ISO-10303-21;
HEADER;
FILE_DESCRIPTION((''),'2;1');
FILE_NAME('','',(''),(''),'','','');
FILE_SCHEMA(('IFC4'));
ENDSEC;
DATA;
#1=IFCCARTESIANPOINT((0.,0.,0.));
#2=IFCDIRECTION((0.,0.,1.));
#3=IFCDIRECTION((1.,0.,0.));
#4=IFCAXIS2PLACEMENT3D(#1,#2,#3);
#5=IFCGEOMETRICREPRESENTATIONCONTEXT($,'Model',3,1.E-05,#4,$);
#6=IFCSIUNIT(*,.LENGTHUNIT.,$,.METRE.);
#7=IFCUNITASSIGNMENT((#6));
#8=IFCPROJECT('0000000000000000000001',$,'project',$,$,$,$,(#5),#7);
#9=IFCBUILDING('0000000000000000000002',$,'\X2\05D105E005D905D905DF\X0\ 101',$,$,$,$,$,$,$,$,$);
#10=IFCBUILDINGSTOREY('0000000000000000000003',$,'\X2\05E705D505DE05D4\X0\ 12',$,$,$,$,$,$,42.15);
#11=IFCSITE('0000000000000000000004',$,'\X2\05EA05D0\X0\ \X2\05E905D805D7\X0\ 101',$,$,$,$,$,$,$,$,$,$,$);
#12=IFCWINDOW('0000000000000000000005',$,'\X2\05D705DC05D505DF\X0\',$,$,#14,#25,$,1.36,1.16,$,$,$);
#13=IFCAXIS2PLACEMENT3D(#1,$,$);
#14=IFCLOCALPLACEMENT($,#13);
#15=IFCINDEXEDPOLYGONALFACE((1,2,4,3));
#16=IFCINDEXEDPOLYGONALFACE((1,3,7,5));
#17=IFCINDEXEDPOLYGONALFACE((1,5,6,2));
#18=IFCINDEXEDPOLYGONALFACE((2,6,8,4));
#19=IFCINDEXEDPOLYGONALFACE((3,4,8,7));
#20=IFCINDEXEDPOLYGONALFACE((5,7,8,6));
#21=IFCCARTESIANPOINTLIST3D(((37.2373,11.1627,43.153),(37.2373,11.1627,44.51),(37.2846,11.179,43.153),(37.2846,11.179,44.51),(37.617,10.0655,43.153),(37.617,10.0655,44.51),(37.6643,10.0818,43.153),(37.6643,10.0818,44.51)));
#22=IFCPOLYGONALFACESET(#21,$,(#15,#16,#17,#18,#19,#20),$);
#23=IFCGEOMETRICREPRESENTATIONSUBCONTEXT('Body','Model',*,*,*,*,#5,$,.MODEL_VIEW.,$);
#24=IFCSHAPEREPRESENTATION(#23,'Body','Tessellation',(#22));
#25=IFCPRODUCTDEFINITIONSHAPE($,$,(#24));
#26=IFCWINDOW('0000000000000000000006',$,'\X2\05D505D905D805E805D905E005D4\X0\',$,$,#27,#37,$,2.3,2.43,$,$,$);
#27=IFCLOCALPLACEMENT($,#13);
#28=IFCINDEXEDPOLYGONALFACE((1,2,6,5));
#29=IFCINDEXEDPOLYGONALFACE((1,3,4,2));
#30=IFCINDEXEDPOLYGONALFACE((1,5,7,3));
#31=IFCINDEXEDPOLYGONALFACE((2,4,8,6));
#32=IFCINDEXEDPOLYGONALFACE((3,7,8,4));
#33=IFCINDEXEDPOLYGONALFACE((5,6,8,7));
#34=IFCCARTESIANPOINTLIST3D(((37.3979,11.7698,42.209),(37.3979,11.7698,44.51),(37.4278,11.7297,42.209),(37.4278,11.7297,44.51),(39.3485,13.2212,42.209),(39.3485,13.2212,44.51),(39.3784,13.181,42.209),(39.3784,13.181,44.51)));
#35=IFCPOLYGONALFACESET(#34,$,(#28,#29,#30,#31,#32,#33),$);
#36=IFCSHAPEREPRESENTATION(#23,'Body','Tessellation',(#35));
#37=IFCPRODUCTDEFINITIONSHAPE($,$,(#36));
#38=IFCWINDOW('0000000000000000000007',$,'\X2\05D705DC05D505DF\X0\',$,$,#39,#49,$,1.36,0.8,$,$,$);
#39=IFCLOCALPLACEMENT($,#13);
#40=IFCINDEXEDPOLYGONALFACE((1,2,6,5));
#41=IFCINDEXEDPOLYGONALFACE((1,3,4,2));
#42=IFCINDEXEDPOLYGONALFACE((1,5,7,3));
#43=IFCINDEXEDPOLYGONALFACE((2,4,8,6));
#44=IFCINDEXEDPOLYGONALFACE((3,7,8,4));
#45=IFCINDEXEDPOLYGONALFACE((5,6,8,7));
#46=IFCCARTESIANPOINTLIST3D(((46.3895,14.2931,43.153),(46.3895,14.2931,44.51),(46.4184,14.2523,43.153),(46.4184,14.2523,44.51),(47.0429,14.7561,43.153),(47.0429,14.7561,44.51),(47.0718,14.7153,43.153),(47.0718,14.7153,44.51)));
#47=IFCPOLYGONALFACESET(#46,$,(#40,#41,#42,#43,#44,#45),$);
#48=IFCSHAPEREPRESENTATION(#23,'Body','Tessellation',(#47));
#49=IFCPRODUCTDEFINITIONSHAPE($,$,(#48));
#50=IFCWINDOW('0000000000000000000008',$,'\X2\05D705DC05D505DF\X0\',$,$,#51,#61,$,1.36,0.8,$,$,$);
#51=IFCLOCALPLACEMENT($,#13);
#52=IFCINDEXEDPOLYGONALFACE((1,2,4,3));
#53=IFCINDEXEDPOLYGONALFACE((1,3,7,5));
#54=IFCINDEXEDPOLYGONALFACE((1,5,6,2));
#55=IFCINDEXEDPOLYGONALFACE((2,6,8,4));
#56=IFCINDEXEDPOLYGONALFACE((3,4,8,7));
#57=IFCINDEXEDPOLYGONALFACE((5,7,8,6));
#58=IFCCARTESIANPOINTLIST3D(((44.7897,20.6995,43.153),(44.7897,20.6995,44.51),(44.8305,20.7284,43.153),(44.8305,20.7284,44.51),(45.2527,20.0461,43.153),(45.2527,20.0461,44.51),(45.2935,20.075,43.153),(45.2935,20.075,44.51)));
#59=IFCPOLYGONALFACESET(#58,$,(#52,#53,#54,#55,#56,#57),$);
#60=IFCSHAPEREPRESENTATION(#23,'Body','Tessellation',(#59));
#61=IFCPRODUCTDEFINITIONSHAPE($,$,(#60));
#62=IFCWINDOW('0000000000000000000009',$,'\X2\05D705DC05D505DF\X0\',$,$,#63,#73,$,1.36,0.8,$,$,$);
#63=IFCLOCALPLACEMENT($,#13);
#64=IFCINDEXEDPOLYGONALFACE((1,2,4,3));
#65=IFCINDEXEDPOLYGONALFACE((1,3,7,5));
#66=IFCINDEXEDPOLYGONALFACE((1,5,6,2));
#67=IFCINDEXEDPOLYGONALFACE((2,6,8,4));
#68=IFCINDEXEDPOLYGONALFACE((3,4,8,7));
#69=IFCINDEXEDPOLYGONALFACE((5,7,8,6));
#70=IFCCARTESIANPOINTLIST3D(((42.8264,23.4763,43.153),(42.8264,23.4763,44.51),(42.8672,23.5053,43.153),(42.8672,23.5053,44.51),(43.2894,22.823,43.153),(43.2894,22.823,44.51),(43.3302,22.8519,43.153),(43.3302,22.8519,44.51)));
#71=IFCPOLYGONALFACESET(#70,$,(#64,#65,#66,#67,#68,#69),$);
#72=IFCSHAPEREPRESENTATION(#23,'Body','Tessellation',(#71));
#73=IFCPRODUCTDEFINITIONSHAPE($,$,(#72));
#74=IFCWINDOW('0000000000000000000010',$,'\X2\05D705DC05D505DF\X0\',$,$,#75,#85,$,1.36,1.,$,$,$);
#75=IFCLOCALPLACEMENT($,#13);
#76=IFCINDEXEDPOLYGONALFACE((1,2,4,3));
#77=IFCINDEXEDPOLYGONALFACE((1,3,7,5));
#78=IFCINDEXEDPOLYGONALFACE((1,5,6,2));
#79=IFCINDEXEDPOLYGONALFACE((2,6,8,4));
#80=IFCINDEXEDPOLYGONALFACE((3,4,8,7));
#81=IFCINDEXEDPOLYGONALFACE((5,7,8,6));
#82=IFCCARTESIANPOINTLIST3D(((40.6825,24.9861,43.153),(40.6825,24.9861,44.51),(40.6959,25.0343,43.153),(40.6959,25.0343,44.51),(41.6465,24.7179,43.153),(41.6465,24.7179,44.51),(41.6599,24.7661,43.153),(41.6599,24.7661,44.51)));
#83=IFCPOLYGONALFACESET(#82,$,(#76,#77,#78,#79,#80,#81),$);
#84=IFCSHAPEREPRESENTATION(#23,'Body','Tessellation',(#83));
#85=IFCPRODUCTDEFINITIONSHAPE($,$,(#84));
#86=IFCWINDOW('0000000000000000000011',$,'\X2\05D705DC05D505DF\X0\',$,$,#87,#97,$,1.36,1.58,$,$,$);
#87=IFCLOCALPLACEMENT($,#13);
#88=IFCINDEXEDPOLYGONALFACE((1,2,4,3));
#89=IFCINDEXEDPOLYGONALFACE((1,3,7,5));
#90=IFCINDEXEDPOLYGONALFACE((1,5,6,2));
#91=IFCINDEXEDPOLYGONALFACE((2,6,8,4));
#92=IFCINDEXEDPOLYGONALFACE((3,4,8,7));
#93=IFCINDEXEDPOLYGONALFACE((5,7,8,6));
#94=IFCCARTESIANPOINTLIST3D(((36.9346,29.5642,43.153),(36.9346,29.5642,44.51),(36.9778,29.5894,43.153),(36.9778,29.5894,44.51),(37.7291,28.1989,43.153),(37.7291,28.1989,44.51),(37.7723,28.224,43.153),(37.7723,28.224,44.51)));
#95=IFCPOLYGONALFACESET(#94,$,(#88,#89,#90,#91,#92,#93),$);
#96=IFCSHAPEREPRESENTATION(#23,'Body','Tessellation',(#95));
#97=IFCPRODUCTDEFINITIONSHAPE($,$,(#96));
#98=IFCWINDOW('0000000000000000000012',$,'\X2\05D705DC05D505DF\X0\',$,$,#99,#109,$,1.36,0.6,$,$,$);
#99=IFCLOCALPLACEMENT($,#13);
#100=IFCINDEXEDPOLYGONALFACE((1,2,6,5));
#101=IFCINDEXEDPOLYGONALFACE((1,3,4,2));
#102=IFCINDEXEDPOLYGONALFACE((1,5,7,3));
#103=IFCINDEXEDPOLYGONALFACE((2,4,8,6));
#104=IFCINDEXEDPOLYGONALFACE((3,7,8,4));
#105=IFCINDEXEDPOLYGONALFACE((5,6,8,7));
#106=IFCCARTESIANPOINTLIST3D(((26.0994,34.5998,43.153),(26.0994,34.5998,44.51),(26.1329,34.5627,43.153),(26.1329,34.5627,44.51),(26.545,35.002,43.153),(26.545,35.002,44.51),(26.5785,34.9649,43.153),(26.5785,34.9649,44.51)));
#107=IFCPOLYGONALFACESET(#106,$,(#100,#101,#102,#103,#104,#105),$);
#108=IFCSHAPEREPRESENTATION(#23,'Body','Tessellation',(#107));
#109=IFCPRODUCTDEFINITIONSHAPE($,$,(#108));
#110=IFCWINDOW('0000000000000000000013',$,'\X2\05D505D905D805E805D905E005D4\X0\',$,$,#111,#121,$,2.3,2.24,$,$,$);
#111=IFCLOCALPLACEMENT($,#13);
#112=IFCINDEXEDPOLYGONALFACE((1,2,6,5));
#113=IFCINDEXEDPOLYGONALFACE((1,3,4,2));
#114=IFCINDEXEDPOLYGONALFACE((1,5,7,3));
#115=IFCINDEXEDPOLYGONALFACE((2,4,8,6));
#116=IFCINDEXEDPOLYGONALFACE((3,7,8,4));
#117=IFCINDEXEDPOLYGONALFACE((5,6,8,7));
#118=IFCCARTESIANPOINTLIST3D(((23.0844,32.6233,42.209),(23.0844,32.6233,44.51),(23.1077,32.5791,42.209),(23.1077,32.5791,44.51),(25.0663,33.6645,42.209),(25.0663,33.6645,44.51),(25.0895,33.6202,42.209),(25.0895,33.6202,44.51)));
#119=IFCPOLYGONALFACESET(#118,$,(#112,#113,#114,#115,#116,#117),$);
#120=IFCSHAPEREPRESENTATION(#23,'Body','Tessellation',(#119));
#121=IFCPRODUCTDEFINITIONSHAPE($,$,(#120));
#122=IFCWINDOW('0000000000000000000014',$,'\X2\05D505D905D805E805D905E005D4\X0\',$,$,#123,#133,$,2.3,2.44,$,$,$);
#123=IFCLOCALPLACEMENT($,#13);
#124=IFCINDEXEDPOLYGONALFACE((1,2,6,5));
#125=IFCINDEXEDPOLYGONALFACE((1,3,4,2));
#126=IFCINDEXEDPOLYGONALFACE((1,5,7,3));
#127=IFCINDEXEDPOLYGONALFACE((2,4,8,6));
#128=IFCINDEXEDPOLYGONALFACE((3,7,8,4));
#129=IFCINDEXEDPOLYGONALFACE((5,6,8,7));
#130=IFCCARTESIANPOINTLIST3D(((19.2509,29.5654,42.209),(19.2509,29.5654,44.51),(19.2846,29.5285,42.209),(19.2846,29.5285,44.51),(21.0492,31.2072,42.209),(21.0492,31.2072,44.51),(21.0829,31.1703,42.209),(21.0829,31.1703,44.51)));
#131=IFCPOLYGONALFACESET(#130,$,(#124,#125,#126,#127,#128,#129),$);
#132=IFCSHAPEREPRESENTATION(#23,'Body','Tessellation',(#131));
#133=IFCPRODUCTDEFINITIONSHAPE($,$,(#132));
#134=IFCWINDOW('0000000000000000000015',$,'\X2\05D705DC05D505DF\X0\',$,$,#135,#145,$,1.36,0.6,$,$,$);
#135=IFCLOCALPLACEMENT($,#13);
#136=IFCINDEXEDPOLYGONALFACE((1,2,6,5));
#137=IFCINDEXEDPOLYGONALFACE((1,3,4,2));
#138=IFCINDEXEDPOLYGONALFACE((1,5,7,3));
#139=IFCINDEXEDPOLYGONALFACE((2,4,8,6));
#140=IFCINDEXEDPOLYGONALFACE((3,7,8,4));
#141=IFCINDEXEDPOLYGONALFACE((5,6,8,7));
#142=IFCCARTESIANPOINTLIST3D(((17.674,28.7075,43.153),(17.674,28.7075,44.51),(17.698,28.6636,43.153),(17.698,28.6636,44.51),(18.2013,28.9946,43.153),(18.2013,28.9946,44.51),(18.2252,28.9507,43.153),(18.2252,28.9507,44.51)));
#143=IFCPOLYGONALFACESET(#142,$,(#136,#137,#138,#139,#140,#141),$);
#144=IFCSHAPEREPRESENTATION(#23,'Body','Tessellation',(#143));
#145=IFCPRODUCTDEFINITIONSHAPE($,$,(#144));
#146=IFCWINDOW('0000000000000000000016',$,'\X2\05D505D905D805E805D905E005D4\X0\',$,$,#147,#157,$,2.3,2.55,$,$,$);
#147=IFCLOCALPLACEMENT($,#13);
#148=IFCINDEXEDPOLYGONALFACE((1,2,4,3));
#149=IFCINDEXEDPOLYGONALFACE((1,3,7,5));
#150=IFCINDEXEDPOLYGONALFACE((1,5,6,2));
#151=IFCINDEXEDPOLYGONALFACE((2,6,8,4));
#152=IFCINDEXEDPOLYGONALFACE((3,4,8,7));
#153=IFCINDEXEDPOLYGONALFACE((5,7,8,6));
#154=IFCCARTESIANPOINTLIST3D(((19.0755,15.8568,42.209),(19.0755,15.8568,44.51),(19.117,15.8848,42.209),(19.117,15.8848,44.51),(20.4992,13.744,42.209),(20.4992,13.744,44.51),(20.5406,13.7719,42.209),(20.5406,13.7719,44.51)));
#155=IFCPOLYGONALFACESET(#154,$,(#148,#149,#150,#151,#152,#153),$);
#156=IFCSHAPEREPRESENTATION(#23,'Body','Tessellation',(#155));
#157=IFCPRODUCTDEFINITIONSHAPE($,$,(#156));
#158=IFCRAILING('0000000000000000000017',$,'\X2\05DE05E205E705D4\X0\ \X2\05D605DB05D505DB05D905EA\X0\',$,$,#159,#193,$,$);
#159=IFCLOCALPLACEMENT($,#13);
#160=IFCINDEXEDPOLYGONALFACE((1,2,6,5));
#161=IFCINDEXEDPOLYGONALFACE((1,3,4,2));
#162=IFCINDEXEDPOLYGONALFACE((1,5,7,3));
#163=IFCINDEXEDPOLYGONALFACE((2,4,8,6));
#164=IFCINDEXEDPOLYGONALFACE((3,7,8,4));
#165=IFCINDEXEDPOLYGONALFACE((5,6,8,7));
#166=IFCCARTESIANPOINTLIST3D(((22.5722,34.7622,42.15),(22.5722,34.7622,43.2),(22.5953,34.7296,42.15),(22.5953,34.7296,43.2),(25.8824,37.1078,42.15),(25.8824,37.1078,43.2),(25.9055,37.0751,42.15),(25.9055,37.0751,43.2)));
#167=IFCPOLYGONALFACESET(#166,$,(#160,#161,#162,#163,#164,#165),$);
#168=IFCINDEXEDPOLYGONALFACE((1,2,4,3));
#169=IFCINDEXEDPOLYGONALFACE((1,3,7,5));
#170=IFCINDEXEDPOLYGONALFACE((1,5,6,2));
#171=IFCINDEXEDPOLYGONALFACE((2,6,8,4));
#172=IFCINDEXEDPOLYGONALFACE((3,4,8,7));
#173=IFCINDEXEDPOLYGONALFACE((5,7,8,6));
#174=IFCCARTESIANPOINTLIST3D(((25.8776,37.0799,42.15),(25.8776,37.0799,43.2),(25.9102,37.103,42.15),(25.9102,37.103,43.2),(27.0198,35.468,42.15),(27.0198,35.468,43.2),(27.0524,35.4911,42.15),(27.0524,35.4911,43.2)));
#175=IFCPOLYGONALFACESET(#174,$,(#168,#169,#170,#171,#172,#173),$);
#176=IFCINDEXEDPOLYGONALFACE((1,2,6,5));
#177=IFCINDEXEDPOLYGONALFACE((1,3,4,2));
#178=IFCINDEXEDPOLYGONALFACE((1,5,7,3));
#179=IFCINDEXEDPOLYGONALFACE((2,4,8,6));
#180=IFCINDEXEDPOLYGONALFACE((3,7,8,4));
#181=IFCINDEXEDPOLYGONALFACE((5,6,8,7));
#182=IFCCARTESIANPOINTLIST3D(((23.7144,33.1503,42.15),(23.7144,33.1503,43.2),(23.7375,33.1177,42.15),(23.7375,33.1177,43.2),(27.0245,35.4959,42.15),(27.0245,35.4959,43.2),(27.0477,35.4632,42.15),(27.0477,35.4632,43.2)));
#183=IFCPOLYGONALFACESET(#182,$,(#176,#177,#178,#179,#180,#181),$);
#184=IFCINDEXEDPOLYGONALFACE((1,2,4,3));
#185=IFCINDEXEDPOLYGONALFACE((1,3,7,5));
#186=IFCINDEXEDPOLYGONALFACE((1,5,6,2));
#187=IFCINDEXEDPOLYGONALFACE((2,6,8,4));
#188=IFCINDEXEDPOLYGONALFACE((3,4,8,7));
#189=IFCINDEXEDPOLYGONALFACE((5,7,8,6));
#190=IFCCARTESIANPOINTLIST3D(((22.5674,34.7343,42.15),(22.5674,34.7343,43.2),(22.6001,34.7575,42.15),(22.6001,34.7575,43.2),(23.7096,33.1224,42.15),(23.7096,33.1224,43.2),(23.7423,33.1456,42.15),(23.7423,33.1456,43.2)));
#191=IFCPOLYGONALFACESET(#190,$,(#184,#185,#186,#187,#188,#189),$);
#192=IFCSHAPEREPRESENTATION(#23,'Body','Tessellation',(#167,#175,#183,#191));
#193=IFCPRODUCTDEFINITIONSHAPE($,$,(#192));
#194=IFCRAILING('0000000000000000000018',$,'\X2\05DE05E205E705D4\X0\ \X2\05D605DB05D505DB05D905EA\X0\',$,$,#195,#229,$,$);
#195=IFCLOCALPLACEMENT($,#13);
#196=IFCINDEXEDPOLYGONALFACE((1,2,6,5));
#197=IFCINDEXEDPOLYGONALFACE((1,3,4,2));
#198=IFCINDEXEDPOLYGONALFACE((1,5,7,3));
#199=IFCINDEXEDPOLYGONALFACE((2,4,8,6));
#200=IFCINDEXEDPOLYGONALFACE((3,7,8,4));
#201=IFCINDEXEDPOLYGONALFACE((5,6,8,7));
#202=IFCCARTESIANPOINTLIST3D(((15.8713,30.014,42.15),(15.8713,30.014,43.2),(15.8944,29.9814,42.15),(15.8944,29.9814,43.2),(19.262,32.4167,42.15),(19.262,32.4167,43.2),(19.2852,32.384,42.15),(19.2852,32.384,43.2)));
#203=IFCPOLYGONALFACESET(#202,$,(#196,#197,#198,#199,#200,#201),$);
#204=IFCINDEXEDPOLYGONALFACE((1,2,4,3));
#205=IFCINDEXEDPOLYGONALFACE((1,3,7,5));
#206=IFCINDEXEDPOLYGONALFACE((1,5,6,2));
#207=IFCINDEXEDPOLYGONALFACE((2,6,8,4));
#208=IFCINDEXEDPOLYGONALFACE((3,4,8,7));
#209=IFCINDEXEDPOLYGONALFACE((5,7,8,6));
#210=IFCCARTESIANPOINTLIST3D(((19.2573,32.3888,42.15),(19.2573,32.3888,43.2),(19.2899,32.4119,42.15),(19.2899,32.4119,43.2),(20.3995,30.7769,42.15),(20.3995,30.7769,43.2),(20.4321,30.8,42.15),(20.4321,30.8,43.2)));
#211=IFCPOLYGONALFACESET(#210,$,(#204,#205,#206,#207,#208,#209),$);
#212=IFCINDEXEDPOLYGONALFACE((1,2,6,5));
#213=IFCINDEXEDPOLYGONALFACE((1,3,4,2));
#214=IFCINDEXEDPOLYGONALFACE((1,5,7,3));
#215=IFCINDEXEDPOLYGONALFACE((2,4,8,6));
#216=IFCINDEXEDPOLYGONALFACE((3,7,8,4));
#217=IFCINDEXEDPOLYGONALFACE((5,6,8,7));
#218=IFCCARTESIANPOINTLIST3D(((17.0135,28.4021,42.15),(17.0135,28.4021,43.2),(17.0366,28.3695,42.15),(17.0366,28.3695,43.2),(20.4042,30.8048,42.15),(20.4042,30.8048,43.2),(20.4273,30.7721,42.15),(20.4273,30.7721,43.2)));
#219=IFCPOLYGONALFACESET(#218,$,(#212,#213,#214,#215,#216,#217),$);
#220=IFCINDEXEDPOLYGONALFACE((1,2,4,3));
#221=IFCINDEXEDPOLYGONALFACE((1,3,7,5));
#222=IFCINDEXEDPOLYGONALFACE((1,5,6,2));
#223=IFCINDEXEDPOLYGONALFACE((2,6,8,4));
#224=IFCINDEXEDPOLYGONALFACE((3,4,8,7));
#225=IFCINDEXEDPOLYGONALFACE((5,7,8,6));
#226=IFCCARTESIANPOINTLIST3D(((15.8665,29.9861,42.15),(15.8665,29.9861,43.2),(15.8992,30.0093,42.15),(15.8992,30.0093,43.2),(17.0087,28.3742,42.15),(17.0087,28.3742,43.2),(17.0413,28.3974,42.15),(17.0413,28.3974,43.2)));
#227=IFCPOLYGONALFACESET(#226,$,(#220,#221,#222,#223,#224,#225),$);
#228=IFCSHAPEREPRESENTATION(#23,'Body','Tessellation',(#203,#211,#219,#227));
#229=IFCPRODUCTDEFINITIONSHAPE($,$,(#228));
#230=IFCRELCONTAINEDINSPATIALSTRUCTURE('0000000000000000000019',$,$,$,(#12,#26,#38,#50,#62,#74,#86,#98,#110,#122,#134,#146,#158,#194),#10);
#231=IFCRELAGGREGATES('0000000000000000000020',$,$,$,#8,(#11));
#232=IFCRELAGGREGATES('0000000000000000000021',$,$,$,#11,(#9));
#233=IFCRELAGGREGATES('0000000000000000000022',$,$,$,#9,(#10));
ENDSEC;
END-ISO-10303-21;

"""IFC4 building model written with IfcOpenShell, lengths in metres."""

from ifc_helpers import new_model, si_unit, frame, origin_with_axes, context, subcontext, project, spatial, polyline, outline, extrude, element, save


model = new_model("IFC4")

# Units and contexts
model_context = context("Model", 3, precision=1e-05, world=origin_with_axes())
body_context = subcontext(model_context, "Body", "Model", "MODEL_VIEW")
ifc_project = project(units=[si_unit("LENGTHUNIT", "METRE")], contexts=[model_context])

# Site, building, storey
site = spatial("IfcSite", under=ifc_project, Name="תא שטח 101")
building = spatial("IfcBuilding", under=site, Name="בניין 101")
storey = spatial("IfcBuildingStorey", under=building, Name="קומה 12", Elevation=42.15)

# Windows
element("IfcWindow", 1, inside=storey, Name="חלון", OverallHeight=1.36, OverallWidth=1.16, context=body_context, shape_type="SweptSolid", body=[
    extrude(outline(polyline([(37.6643, 10.0818), (37.2846, 11.179), (37.2373, 11.1627), (37.617, 10.0655), (37.6643, 10.0818)])), frame((0.0, 0.0, 43.153)), (0.0, 0.0, 1.0), 1.357),
])
element("IfcWindow", 2, inside=storey, Name="ויטרינה", OverallHeight=2.3, OverallWidth=2.43, context=body_context, shape_type="SweptSolid", body=[
    extrude(outline(polyline([(37.4278, 11.7297), (39.3784, 13.181), (39.3485, 13.2212), (37.3979, 11.7698), (37.4278, 11.7297)])), frame((0.0, 0.0, 42.209)), (0.0, 0.0, 1.0), 2.301),
])
element("IfcWindow", 3, inside=storey, Name="חלון", OverallHeight=1.36, OverallWidth=0.8, context=body_context, shape_type="SweptSolid", body=[
    extrude(outline(polyline([(46.4184, 14.2523), (47.0718, 14.7153), (47.0429, 14.7561), (46.3895, 14.2931), (46.4184, 14.2523)])), frame((0.0, 0.0, 43.153)), (0.0, 0.0, 1.0), 1.357),
])
element("IfcWindow", 4, inside=storey, Name="חלון", OverallHeight=1.36, OverallWidth=0.8, context=body_context, shape_type="SweptSolid", body=[
    extrude(outline(polyline([(45.2935, 20.075), (44.8305, 20.7284), (44.7897, 20.6995), (45.2527, 20.0461), (45.2935, 20.075)])), frame((0.0, 0.0, 43.153)), (0.0, 0.0, 1.0), 1.357),
])
element("IfcWindow", 5, inside=storey, Name="חלון", OverallHeight=1.36, OverallWidth=0.8, context=body_context, shape_type="SweptSolid", body=[
    extrude(outline(polyline([(43.3302, 22.8519), (42.8672, 23.5053), (42.8264, 23.4763), (43.2894, 22.823), (43.3302, 22.8519)])), frame((0.0, 0.0, 43.153)), (0.0, 0.0, 1.0), 1.357),
])
element("IfcWindow", 6, inside=storey, Name="חלון", OverallHeight=1.36, OverallWidth=1.0, context=body_context, shape_type="SweptSolid", body=[
    extrude(outline(polyline([(41.6599, 24.7661), (40.6959, 25.0343), (40.6825, 24.9861), (41.6465, 24.7179), (41.6599, 24.7661)])), frame((0.0, 0.0, 43.153)), (0.0, 0.0, 1.0), 1.357),
])
element("IfcWindow", 7, inside=storey, Name="חלון", OverallHeight=1.36, OverallWidth=1.58, context=body_context, shape_type="SweptSolid", body=[
    extrude(outline(polyline([(37.7723, 28.224), (36.9778, 29.5894), (36.9346, 29.5642), (37.7291, 28.1989), (37.7723, 28.224)])), frame((0.0, 0.0, 43.153)), (0.0, 0.0, 1.0), 1.357),
])
element("IfcWindow", 8, inside=storey, Name="חלון", OverallHeight=1.36, OverallWidth=0.6, context=body_context, shape_type="SweptSolid", body=[
    extrude(outline(polyline([(26.545, 35.002), (26.0994, 34.5998), (26.1329, 34.5627), (26.5785, 34.9649), (26.545, 35.002)])), frame((0.0, 0.0, 43.153)), (0.0, 0.0, 1.0), 1.357),
])
element("IfcWindow", 9, inside=storey, Name="ויטרינה", OverallHeight=2.3, OverallWidth=2.24, context=body_context, shape_type="SweptSolid", body=[
    extrude(outline(polyline([(25.0663, 33.6645), (23.0844, 32.6233), (23.1077, 32.5791), (25.0895, 33.6202), (25.0663, 33.6645)])), frame((0.0, 0.0, 42.209)), (0.0, 0.0, 1.0), 2.301),
])
element("IfcWindow", 10, inside=storey, Name="ויטרינה", OverallHeight=2.3, OverallWidth=2.44, context=body_context, shape_type="SweptSolid", body=[
    extrude(outline(polyline([(21.0492, 31.2072), (19.2509, 29.5654), (19.2846, 29.5285), (21.0829, 31.1703), (21.0492, 31.2072)])), frame((0.0, 0.0, 42.209)), (0.0, 0.0, 1.0), 2.301),
])
element("IfcWindow", 11, inside=storey, Name="חלון", OverallHeight=1.36, OverallWidth=0.6, context=body_context, shape_type="SweptSolid", body=[
    extrude(outline(polyline([(18.2013, 28.9946), (17.674, 28.7075), (17.698, 28.6636), (18.2252, 28.9507), (18.2013, 28.9946)])), frame((0.0, 0.0, 43.153)), (0.0, 0.0, 1.0), 1.357),
])
element("IfcWindow", 12, inside=storey, Name="ויטרינה", OverallHeight=2.3, OverallWidth=2.55, context=body_context, shape_type="SweptSolid", body=[
    extrude(outline(polyline([(19.0755, 15.8568), (20.4992, 13.744), (20.5406, 13.7719), (19.117, 15.8848), (19.0755, 15.8568)])), frame((0.0, 0.0, 42.209)), (0.0, 0.0, 1.0), 2.301),
])

# Railings
element("IfcRailing", 13, inside=storey, Name="מעקה זכוכית", context=body_context, shape_type="SweptSolid", body=[
    extrude(outline(polyline([(22.5953, 34.7296), (25.9055, 37.0751), (25.8824, 37.1078), (22.5722, 34.7622), (22.5953, 34.7296)])), frame((0.0, 0.0, 42.15)), (0.0, 0.0, 1.0), 1.05),
    extrude(outline(polyline([(25.8776, 37.0799), (27.0198, 35.468), (27.0524, 35.4911), (25.9102, 37.103), (25.8776, 37.0799)])), frame((0.0, 0.0, 42.15)), (0.0, 0.0, 1.0), 1.05),
    extrude(outline(polyline([(27.0245, 35.4959), (23.7144, 33.1503), (23.7375, 33.1177), (27.0477, 35.4632), (27.0245, 35.4959)])), frame((0.0, 0.0, 42.15)), (0.0, 0.0, 1.0), 1.05),
    extrude(outline(polyline([(23.7423, 33.1456), (22.6001, 34.7575), (22.5674, 34.7343), (23.7096, 33.1224), (23.7423, 33.1456)])), frame((0.0, 0.0, 42.15)), (0.0, 0.0, 1.0), 1.05),
])
element("IfcRailing", 14, inside=storey, Name="מעקה זכוכית", context=body_context, shape_type="SweptSolid", body=[
    extrude(outline(polyline([(15.8944, 29.9814), (19.2852, 32.384), (19.262, 32.4167), (15.8713, 30.014), (15.8944, 29.9814)])), frame((0.0, 0.0, 42.15)), (0.0, 0.0, 1.0), 1.05),
    extrude(outline(polyline([(19.2573, 32.3888), (20.3995, 30.7769), (20.4321, 30.8), (19.2899, 32.4119), (19.2573, 32.3888)])), frame((0.0, 0.0, 42.15)), (0.0, 0.0, 1.0), 1.05),
    extrude(outline(polyline([(20.4042, 30.8048), (17.0135, 28.4021), (17.0366, 28.3695), (20.4273, 30.7721), (20.4042, 30.8048)])), frame((0.0, 0.0, 42.15)), (0.0, 0.0, 1.0), 1.05),
    extrude(outline(polyline([(17.0413, 28.3974), (15.8992, 30.0093), (15.8665, 29.9861), (17.0087, 28.3742), (17.0413, 28.3974)])), frame((0.0, 0.0, 42.15)), (0.0, 0.0, 1.0), 1.05),
])

save(model, "model.ifc")
